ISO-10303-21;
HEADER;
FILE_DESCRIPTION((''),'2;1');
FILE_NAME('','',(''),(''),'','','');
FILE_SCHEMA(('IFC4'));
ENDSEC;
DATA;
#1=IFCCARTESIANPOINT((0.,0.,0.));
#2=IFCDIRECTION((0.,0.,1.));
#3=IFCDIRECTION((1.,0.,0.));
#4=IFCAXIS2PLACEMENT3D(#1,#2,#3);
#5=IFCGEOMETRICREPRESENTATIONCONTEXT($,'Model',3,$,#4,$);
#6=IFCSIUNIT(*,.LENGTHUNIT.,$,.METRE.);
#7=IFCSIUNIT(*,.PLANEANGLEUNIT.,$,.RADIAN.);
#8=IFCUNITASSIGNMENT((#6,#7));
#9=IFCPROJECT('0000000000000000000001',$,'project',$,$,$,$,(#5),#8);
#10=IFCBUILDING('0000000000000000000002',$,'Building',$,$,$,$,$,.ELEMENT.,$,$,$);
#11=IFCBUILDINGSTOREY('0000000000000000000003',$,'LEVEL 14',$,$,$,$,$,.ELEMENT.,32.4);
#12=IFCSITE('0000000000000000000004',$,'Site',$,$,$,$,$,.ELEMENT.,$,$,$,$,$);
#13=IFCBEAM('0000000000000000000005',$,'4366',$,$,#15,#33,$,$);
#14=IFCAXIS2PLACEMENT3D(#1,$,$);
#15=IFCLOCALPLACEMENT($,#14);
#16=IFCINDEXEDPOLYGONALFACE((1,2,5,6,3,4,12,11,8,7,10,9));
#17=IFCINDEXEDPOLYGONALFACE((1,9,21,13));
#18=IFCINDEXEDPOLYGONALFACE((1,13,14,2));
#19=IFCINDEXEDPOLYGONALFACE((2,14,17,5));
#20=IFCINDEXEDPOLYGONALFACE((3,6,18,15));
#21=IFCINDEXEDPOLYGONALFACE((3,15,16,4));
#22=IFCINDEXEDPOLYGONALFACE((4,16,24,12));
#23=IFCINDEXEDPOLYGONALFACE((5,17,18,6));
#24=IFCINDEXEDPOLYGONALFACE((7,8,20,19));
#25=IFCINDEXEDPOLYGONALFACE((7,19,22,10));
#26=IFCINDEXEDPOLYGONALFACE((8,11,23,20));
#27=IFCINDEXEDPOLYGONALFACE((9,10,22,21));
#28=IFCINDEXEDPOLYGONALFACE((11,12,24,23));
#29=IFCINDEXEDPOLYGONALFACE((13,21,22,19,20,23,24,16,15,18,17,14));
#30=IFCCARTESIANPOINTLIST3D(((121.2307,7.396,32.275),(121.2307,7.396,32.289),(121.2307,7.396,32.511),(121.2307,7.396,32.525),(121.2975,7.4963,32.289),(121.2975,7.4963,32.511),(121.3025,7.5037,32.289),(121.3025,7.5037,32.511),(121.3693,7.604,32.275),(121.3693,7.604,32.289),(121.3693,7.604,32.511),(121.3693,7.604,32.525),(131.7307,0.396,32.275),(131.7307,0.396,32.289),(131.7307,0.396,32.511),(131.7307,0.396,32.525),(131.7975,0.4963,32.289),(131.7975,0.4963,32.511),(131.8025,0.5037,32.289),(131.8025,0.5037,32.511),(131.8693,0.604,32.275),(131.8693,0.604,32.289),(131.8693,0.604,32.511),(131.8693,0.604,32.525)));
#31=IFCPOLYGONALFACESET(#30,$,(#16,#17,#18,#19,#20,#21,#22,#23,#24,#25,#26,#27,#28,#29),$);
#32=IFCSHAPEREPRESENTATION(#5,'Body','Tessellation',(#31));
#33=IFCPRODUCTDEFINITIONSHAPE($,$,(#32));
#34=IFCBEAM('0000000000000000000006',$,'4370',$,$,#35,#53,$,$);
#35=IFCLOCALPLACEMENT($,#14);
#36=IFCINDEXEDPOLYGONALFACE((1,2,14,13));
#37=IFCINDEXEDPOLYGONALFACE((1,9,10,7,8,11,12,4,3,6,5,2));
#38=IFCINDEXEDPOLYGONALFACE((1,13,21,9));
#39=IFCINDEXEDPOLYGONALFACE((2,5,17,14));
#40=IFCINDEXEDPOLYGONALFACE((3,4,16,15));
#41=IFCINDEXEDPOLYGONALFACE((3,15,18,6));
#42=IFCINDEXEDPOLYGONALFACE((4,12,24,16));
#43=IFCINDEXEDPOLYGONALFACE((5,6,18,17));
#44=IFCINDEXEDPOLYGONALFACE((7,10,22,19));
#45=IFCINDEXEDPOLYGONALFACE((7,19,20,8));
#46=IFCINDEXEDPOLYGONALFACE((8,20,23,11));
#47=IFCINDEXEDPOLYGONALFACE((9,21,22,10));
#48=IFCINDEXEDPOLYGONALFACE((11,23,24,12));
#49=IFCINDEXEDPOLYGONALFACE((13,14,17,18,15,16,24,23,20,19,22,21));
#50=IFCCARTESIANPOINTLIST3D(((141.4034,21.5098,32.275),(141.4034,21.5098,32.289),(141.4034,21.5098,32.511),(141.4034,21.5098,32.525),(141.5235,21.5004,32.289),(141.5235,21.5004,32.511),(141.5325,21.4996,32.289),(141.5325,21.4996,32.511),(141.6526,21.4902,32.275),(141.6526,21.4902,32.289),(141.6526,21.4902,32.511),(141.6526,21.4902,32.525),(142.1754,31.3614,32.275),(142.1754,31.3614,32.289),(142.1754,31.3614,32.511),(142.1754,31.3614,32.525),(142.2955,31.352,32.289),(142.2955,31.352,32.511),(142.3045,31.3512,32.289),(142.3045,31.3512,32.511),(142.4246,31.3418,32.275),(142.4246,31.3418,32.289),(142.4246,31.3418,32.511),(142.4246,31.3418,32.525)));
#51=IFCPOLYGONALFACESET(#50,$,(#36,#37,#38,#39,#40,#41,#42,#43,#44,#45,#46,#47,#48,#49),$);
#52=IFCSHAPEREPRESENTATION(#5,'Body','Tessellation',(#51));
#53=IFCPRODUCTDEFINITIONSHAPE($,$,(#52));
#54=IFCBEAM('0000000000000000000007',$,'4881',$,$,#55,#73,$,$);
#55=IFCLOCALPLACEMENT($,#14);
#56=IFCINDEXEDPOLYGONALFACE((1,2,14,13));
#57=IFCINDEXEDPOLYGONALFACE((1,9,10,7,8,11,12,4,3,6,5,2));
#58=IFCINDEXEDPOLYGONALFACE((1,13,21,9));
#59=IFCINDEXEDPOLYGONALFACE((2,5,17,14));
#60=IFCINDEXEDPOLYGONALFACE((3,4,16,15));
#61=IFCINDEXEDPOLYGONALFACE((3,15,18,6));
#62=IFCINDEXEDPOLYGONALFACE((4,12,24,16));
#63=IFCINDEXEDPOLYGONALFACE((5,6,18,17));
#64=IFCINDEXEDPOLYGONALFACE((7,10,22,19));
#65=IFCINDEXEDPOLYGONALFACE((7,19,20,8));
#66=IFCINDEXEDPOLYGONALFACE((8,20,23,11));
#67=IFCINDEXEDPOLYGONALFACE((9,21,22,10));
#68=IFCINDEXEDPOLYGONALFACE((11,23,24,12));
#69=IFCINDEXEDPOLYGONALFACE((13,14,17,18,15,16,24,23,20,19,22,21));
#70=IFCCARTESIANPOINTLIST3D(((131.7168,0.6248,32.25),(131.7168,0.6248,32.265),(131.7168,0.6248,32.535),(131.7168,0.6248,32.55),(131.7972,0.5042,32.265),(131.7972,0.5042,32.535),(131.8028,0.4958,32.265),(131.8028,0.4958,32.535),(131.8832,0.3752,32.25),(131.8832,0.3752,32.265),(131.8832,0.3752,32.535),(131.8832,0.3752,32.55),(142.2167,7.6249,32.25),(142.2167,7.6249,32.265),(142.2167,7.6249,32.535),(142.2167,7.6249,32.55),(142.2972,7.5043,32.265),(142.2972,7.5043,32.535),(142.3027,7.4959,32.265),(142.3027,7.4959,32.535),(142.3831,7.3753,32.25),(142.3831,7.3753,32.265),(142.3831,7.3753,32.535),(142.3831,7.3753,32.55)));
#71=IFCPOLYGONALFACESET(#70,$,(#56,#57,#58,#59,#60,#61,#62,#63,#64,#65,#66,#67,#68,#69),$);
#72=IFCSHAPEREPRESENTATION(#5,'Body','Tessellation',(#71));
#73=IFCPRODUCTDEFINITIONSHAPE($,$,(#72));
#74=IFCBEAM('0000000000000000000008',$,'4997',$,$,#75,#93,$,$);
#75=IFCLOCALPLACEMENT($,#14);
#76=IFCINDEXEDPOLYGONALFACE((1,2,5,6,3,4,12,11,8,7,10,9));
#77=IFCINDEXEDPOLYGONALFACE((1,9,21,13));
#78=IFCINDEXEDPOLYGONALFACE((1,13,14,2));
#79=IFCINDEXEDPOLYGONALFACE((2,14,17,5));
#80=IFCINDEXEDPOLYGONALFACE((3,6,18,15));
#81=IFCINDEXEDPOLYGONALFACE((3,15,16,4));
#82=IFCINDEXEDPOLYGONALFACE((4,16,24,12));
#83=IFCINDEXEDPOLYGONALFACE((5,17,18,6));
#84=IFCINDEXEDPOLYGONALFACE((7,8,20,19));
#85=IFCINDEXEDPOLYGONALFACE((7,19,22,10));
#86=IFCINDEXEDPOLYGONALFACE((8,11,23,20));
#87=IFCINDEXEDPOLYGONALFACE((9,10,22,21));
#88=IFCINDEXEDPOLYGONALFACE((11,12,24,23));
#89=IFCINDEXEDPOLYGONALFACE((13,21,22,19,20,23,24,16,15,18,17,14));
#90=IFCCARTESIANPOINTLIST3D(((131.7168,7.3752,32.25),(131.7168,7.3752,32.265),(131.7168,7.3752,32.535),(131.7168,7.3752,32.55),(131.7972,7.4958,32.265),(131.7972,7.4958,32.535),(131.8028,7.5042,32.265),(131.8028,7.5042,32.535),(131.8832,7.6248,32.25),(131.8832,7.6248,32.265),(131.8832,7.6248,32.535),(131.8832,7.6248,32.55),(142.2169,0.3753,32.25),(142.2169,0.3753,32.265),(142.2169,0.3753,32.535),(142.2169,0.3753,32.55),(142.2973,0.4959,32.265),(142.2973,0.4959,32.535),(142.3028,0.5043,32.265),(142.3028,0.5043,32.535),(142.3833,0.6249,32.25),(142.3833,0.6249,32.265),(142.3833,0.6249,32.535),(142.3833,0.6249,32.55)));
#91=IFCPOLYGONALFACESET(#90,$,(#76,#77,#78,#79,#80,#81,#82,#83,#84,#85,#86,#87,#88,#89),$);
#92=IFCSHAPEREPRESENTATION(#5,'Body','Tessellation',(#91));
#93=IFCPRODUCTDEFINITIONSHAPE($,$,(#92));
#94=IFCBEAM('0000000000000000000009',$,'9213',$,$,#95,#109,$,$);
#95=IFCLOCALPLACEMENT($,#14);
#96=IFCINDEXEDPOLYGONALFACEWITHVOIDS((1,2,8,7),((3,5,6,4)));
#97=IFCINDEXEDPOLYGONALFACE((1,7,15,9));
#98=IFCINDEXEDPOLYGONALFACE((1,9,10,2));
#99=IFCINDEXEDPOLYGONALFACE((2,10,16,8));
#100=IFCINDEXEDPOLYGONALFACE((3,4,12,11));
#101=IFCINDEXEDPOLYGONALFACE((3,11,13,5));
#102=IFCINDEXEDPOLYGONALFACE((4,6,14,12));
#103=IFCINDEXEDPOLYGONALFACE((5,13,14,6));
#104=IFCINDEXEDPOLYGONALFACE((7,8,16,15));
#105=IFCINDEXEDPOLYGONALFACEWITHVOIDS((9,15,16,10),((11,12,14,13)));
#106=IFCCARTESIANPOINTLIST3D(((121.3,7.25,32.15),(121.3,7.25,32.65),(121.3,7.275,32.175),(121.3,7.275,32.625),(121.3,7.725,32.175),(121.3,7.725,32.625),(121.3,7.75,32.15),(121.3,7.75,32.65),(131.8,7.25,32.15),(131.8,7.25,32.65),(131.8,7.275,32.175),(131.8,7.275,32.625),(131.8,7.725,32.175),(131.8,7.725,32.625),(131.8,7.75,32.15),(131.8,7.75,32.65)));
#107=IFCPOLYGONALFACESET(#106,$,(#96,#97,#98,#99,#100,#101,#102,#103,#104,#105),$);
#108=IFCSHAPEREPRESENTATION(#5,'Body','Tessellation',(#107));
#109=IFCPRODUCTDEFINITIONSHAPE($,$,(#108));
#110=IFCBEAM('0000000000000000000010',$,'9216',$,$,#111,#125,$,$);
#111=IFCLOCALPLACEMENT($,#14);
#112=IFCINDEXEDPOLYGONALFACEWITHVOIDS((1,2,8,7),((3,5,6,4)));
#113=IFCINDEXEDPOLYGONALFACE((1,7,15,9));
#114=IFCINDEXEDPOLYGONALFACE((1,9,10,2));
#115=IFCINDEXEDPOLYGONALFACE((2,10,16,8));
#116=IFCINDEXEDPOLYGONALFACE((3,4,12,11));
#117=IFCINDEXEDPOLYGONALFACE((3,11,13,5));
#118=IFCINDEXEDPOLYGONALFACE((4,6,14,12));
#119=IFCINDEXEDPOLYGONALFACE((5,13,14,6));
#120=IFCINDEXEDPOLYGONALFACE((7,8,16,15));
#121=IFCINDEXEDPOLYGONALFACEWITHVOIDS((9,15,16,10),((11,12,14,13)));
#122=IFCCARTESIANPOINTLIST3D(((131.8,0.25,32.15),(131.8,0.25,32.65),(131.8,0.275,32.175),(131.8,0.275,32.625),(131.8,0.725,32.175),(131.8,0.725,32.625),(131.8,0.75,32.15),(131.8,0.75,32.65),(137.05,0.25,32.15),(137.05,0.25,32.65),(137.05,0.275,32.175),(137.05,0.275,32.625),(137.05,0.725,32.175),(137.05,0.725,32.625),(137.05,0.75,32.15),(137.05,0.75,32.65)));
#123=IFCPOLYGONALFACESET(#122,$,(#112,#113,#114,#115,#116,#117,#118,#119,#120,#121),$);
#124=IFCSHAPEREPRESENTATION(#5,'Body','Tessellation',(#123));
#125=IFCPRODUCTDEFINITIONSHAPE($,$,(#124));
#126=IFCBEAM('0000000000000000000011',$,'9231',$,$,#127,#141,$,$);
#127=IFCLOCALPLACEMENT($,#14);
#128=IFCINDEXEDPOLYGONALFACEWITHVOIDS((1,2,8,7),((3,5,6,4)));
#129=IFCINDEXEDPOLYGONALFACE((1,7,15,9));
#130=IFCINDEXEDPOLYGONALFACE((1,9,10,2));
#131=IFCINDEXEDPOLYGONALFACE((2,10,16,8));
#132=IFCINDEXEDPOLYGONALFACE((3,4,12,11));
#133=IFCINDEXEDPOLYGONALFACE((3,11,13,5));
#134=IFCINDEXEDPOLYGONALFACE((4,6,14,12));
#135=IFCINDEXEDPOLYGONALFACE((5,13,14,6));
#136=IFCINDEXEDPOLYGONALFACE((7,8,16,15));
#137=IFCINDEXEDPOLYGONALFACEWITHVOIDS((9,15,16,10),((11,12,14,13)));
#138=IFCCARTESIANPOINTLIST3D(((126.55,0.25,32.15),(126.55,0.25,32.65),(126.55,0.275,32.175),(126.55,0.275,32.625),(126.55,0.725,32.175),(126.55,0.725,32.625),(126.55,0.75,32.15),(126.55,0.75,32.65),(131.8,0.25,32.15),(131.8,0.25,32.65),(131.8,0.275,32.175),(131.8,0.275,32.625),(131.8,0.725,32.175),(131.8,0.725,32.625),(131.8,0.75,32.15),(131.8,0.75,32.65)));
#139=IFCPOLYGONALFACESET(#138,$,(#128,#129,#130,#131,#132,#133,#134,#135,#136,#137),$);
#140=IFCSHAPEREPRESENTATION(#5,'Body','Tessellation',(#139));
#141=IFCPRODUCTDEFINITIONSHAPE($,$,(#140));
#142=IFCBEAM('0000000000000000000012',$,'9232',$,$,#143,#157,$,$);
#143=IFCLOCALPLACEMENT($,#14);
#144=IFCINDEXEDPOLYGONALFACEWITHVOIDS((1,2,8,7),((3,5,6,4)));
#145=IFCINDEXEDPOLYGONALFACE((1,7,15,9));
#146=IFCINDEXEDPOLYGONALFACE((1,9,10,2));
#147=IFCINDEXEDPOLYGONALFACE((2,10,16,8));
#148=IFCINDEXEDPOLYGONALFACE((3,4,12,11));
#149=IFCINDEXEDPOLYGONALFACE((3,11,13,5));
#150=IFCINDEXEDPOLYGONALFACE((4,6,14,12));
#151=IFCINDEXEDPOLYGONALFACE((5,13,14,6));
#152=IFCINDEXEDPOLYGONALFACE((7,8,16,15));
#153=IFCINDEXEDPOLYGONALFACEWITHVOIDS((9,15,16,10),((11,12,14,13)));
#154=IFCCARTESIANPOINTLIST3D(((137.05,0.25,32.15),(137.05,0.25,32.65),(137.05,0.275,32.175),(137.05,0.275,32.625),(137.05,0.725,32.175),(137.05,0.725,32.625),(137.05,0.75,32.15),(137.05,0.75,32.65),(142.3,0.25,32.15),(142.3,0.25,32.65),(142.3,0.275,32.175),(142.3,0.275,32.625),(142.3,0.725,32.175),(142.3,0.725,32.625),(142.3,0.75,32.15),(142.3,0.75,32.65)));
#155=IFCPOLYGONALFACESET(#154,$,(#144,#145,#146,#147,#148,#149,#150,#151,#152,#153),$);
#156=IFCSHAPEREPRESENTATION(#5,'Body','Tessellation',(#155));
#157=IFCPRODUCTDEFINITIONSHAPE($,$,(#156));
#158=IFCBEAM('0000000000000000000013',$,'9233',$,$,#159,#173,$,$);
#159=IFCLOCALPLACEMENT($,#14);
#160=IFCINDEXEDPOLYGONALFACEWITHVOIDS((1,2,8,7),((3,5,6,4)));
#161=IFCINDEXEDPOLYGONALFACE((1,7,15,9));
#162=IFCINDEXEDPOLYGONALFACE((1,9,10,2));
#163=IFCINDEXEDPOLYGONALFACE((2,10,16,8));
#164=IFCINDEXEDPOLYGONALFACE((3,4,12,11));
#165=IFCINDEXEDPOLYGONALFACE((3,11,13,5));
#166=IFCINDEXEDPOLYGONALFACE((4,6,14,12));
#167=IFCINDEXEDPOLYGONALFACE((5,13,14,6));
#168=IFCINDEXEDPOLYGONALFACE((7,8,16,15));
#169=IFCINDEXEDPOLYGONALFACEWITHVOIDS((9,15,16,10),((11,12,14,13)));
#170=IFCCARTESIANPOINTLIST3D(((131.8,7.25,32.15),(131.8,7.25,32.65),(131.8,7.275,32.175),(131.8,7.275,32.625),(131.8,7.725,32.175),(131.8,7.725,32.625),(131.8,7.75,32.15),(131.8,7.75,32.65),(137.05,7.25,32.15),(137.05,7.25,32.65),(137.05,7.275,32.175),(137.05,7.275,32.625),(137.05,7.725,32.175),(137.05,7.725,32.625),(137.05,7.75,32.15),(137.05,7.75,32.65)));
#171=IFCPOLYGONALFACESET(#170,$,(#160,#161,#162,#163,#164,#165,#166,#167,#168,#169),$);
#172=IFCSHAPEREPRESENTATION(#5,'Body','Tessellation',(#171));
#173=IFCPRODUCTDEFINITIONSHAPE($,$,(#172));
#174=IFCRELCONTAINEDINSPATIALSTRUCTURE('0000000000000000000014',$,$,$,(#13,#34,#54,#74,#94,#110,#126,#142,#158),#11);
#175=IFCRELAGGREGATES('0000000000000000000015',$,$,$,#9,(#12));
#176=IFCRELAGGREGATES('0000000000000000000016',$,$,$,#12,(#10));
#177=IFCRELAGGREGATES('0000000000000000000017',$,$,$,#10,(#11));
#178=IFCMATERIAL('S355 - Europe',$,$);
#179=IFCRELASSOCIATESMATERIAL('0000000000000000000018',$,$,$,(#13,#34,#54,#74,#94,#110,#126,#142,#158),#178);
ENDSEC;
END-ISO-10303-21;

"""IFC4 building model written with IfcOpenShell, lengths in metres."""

from ifc_helpers import new_model, si_unit, frame, origin_with_axes, origin_2d_with_axis, place, context, project, spatial, hollow_rectangle, i_section, extrude, material, material_profile, profile_set, profile_usage, element, save


model = new_model("IFC4")

# Units and contexts
model_context = context("Model", 3, world=origin_with_axes())
ifc_project = project(units=[si_unit("LENGTHUNIT", "METRE"), si_unit("PLANEANGLEUNIT", "RADIAN")], contexts=[model_context])

# Site, building, storey
site = spatial("IfcSite", under=ifc_project, Name="Site", CompositionType="ELEMENT")
building = spatial("IfcBuilding", under=site, Name="Building", CompositionType="ELEMENT")
storey = spatial("IfcBuildingStorey", under=building, Name="LEVEL 14", CompositionType="ELEMENT", Elevation=32.4)

# Shared definitions
ifc_material = material(Name="S355 - Europe")

# Beams
ifc_material_profile_1 = material_profile(ifc_material, i_section(OverallWidth=0.25, OverallDepth=0.25, WebThickness=0.009, FlangeThickness=0.014, at=origin_2d_with_axis()))
ifc_profile_set_1 = profile_set([ifc_material_profile_1])
ifc_profile_usage_1 = profile_usage(ifc_profile_set_1, cardinal=10)
beam_1_placement = place(None, frame((131.8, 0.5, 32.4), z_axis=(-0.83205, 0.5547, 0.0), x_axis=(-0.5547, -0.83205, 0.0)))
element("IfcBeam", 1, at=beam_1_placement, inside=storey, material=ifc_profile_usage_1, Name="4366", context=model_context, shape_type="SweptSolid", body=[
    extrude(i_section(OverallWidth=0.25, OverallDepth=0.25, WebThickness=0.009, FlangeThickness=0.014, at=origin_2d_with_axis()), origin_with_axes(), (0.0, 0.0, 1.0), 12.6194),
])
ifc_material_profile_2 = material_profile(ifc_material, i_section(OverallWidth=0.25, OverallDepth=0.25, WebThickness=0.009, FlangeThickness=0.014, at=origin_2d_with_axis()))
ifc_profile_set_2 = profile_set([ifc_material_profile_2])
ifc_profile_usage_2 = profile_usage(ifc_profile_set_2, cardinal=10)
beam_2_placement = place(None, frame((141.528, 21.5, 32.4), z_axis=(0.078123, 0.996944, 0.0), x_axis=(-0.996944, 0.078123, 0.0)))
element("IfcBeam", 2, at=beam_2_placement, inside=storey, material=ifc_profile_usage_2, Name="4370", context=model_context, shape_type="SweptSolid", body=[
    extrude(i_section(OverallWidth=0.25, OverallDepth=0.25, WebThickness=0.009, FlangeThickness=0.014, at=origin_2d_with_axis()), origin_with_axes(), (0.0, 0.0, 1.0), 9.8818),
])
ifc_material_profile_3 = material_profile(ifc_material, i_section(OverallWidth=0.3, OverallDepth=0.3, WebThickness=0.01, FlangeThickness=0.015, at=origin_2d_with_axis()))
ifc_profile_set_3 = profile_set([ifc_material_profile_3])
ifc_profile_usage_3 = profile_usage(ifc_profile_set_3, cardinal=10)
beam_3_placement = place(None, frame((131.8, 0.5, 32.4), z_axis=(0.832045, 0.554708, 0.0), x_axis=(-0.554708, 0.832045, 0.0)))
element("IfcBeam", 3, at=beam_3_placement, inside=storey, material=ifc_profile_usage_3, Name="4881", context=model_context, shape_type="SweptSolid", body=[
    extrude(i_section(OverallWidth=0.3, OverallDepth=0.3, WebThickness=0.01, FlangeThickness=0.015, at=origin_2d_with_axis()), origin_with_axes(), (0.0, 0.0, 1.0), 12.6194),
])
ifc_material_profile_4 = material_profile(ifc_material, i_section(OverallWidth=0.3, OverallDepth=0.3, WebThickness=0.01, FlangeThickness=0.015, at=origin_2d_with_axis()))
ifc_profile_set_4 = profile_set([ifc_material_profile_4])
ifc_profile_usage_4 = profile_usage(ifc_profile_set_4, cardinal=10)
beam_4_placement = place(None, frame((131.8, 7.5, 32.4), z_axis=(0.832055, -0.554693, 0.0), x_axis=(0.554693, 0.832055, 0.0)))
element("IfcBeam", 4, at=beam_4_placement, inside=storey, material=ifc_profile_usage_4, Name="4997", context=model_context, shape_type="SweptSolid", body=[
    extrude(i_section(OverallWidth=0.3, OverallDepth=0.3, WebThickness=0.01, FlangeThickness=0.015, at=origin_2d_with_axis()), origin_with_axes(), (0.0, 0.0, 1.0), 12.6194),
])
ifc_material_profile_5 = material_profile(ifc_material, hollow_rectangle(XDim=0.5, YDim=0.5, WallThickness=0.025, at=origin_2d_with_axis()))
ifc_profile_set_5 = profile_set([ifc_material_profile_5])
ifc_profile_usage_5 = profile_usage(ifc_profile_set_5, cardinal=10)
beam_5_placement = place(None, frame((131.8, 7.5, 32.4), z_axis=(-1.0, 0.0, 0.0), x_axis=(0.0, -1.0, 0.0)))
element("IfcBeam", 5, at=beam_5_placement, inside=storey, material=ifc_profile_usage_5, Name="9213", context=model_context, shape_type="SweptSolid", body=[
    extrude(hollow_rectangle(XDim=0.5, YDim=0.5, WallThickness=0.025, at=origin_2d_with_axis()), origin_with_axes(), (0.0, 0.0, 1.0), 10.5),
])
ifc_material_profile_6 = material_profile(ifc_material, hollow_rectangle(XDim=0.5, YDim=0.5, WallThickness=0.025, at=origin_2d_with_axis()))
ifc_profile_set_6 = profile_set([ifc_material_profile_6])
ifc_profile_usage_6 = profile_usage(ifc_profile_set_6, cardinal=10)
beam_6_placement = place(None, frame((131.8, 0.5, 32.4), z_axis=(1.0, 0.0, 0.0), x_axis=(0.0, 1.0, 0.0)))
element("IfcBeam", 6, at=beam_6_placement, inside=storey, material=ifc_profile_usage_6, Name="9216", context=model_context, shape_type="SweptSolid", body=[
    extrude(hollow_rectangle(XDim=0.5, YDim=0.5, WallThickness=0.025, at=origin_2d_with_axis()), origin_with_axes(), (0.0, 0.0, 1.0), 5.25),
])
ifc_material_profile_7 = material_profile(ifc_material, hollow_rectangle(XDim=0.5, YDim=0.5, WallThickness=0.025, at=origin_2d_with_axis()))
ifc_profile_set_7 = profile_set([ifc_material_profile_7])
ifc_profile_usage_7 = profile_usage(ifc_profile_set_7, cardinal=10)
beam_7_placement = place(None, frame((126.55, 0.5, 32.4), z_axis=(1.0, 0.0, 0.0), x_axis=(0.0, 1.0, 0.0)))
element("IfcBeam", 7, at=beam_7_placement, inside=storey, material=ifc_profile_usage_7, Name="9231", context=model_context, shape_type="SweptSolid", body=[
    extrude(hollow_rectangle(XDim=0.5, YDim=0.5, WallThickness=0.025, at=origin_2d_with_axis()), origin_with_axes(), (0.0, 0.0, 1.0), 5.25),
])
ifc_material_profile_8 = material_profile(ifc_material, hollow_rectangle(XDim=0.5, YDim=0.5, WallThickness=0.025, at=origin_2d_with_axis()))
ifc_profile_set_8 = profile_set([ifc_material_profile_8])
ifc_profile_usage_8 = profile_usage(ifc_profile_set_8, cardinal=10)
beam_8_placement = place(None, frame((137.05, 0.5, 32.4), z_axis=(1.0, 0.0, 0.0), x_axis=(0.0, 1.0, 0.0)))
element("IfcBeam", 8, at=beam_8_placement, inside=storey, material=ifc_profile_usage_8, Name="9232", context=model_context, shape_type="SweptSolid", body=[
    extrude(hollow_rectangle(XDim=0.5, YDim=0.5, WallThickness=0.025, at=origin_2d_with_axis()), origin_with_axes(), (0.0, 0.0, 1.0), 5.25),
])
ifc_material_profile_9 = material_profile(ifc_material, hollow_rectangle(XDim=0.5, YDim=0.5, WallThickness=0.025, at=origin_2d_with_axis()))
ifc_profile_set_9 = profile_set([ifc_material_profile_9])
ifc_profile_usage_9 = profile_usage(ifc_profile_set_9, cardinal=10)
beam_9_placement = place(None, frame((137.05, 7.5, 32.4), z_axis=(-1.0, 0.0, 0.0), x_axis=(0.0, -1.0, 0.0)))
element("IfcBeam", 9, at=beam_9_placement, inside=storey, material=ifc_profile_usage_9, Name="9233", context=model_context, shape_type="SweptSolid", body=[
    extrude(hollow_rectangle(XDim=0.5, YDim=0.5, WallThickness=0.025, at=origin_2d_with_axis()), origin_with_axes(), (0.0, 0.0, 1.0), 5.25),
])

save(model, "model.ifc")
